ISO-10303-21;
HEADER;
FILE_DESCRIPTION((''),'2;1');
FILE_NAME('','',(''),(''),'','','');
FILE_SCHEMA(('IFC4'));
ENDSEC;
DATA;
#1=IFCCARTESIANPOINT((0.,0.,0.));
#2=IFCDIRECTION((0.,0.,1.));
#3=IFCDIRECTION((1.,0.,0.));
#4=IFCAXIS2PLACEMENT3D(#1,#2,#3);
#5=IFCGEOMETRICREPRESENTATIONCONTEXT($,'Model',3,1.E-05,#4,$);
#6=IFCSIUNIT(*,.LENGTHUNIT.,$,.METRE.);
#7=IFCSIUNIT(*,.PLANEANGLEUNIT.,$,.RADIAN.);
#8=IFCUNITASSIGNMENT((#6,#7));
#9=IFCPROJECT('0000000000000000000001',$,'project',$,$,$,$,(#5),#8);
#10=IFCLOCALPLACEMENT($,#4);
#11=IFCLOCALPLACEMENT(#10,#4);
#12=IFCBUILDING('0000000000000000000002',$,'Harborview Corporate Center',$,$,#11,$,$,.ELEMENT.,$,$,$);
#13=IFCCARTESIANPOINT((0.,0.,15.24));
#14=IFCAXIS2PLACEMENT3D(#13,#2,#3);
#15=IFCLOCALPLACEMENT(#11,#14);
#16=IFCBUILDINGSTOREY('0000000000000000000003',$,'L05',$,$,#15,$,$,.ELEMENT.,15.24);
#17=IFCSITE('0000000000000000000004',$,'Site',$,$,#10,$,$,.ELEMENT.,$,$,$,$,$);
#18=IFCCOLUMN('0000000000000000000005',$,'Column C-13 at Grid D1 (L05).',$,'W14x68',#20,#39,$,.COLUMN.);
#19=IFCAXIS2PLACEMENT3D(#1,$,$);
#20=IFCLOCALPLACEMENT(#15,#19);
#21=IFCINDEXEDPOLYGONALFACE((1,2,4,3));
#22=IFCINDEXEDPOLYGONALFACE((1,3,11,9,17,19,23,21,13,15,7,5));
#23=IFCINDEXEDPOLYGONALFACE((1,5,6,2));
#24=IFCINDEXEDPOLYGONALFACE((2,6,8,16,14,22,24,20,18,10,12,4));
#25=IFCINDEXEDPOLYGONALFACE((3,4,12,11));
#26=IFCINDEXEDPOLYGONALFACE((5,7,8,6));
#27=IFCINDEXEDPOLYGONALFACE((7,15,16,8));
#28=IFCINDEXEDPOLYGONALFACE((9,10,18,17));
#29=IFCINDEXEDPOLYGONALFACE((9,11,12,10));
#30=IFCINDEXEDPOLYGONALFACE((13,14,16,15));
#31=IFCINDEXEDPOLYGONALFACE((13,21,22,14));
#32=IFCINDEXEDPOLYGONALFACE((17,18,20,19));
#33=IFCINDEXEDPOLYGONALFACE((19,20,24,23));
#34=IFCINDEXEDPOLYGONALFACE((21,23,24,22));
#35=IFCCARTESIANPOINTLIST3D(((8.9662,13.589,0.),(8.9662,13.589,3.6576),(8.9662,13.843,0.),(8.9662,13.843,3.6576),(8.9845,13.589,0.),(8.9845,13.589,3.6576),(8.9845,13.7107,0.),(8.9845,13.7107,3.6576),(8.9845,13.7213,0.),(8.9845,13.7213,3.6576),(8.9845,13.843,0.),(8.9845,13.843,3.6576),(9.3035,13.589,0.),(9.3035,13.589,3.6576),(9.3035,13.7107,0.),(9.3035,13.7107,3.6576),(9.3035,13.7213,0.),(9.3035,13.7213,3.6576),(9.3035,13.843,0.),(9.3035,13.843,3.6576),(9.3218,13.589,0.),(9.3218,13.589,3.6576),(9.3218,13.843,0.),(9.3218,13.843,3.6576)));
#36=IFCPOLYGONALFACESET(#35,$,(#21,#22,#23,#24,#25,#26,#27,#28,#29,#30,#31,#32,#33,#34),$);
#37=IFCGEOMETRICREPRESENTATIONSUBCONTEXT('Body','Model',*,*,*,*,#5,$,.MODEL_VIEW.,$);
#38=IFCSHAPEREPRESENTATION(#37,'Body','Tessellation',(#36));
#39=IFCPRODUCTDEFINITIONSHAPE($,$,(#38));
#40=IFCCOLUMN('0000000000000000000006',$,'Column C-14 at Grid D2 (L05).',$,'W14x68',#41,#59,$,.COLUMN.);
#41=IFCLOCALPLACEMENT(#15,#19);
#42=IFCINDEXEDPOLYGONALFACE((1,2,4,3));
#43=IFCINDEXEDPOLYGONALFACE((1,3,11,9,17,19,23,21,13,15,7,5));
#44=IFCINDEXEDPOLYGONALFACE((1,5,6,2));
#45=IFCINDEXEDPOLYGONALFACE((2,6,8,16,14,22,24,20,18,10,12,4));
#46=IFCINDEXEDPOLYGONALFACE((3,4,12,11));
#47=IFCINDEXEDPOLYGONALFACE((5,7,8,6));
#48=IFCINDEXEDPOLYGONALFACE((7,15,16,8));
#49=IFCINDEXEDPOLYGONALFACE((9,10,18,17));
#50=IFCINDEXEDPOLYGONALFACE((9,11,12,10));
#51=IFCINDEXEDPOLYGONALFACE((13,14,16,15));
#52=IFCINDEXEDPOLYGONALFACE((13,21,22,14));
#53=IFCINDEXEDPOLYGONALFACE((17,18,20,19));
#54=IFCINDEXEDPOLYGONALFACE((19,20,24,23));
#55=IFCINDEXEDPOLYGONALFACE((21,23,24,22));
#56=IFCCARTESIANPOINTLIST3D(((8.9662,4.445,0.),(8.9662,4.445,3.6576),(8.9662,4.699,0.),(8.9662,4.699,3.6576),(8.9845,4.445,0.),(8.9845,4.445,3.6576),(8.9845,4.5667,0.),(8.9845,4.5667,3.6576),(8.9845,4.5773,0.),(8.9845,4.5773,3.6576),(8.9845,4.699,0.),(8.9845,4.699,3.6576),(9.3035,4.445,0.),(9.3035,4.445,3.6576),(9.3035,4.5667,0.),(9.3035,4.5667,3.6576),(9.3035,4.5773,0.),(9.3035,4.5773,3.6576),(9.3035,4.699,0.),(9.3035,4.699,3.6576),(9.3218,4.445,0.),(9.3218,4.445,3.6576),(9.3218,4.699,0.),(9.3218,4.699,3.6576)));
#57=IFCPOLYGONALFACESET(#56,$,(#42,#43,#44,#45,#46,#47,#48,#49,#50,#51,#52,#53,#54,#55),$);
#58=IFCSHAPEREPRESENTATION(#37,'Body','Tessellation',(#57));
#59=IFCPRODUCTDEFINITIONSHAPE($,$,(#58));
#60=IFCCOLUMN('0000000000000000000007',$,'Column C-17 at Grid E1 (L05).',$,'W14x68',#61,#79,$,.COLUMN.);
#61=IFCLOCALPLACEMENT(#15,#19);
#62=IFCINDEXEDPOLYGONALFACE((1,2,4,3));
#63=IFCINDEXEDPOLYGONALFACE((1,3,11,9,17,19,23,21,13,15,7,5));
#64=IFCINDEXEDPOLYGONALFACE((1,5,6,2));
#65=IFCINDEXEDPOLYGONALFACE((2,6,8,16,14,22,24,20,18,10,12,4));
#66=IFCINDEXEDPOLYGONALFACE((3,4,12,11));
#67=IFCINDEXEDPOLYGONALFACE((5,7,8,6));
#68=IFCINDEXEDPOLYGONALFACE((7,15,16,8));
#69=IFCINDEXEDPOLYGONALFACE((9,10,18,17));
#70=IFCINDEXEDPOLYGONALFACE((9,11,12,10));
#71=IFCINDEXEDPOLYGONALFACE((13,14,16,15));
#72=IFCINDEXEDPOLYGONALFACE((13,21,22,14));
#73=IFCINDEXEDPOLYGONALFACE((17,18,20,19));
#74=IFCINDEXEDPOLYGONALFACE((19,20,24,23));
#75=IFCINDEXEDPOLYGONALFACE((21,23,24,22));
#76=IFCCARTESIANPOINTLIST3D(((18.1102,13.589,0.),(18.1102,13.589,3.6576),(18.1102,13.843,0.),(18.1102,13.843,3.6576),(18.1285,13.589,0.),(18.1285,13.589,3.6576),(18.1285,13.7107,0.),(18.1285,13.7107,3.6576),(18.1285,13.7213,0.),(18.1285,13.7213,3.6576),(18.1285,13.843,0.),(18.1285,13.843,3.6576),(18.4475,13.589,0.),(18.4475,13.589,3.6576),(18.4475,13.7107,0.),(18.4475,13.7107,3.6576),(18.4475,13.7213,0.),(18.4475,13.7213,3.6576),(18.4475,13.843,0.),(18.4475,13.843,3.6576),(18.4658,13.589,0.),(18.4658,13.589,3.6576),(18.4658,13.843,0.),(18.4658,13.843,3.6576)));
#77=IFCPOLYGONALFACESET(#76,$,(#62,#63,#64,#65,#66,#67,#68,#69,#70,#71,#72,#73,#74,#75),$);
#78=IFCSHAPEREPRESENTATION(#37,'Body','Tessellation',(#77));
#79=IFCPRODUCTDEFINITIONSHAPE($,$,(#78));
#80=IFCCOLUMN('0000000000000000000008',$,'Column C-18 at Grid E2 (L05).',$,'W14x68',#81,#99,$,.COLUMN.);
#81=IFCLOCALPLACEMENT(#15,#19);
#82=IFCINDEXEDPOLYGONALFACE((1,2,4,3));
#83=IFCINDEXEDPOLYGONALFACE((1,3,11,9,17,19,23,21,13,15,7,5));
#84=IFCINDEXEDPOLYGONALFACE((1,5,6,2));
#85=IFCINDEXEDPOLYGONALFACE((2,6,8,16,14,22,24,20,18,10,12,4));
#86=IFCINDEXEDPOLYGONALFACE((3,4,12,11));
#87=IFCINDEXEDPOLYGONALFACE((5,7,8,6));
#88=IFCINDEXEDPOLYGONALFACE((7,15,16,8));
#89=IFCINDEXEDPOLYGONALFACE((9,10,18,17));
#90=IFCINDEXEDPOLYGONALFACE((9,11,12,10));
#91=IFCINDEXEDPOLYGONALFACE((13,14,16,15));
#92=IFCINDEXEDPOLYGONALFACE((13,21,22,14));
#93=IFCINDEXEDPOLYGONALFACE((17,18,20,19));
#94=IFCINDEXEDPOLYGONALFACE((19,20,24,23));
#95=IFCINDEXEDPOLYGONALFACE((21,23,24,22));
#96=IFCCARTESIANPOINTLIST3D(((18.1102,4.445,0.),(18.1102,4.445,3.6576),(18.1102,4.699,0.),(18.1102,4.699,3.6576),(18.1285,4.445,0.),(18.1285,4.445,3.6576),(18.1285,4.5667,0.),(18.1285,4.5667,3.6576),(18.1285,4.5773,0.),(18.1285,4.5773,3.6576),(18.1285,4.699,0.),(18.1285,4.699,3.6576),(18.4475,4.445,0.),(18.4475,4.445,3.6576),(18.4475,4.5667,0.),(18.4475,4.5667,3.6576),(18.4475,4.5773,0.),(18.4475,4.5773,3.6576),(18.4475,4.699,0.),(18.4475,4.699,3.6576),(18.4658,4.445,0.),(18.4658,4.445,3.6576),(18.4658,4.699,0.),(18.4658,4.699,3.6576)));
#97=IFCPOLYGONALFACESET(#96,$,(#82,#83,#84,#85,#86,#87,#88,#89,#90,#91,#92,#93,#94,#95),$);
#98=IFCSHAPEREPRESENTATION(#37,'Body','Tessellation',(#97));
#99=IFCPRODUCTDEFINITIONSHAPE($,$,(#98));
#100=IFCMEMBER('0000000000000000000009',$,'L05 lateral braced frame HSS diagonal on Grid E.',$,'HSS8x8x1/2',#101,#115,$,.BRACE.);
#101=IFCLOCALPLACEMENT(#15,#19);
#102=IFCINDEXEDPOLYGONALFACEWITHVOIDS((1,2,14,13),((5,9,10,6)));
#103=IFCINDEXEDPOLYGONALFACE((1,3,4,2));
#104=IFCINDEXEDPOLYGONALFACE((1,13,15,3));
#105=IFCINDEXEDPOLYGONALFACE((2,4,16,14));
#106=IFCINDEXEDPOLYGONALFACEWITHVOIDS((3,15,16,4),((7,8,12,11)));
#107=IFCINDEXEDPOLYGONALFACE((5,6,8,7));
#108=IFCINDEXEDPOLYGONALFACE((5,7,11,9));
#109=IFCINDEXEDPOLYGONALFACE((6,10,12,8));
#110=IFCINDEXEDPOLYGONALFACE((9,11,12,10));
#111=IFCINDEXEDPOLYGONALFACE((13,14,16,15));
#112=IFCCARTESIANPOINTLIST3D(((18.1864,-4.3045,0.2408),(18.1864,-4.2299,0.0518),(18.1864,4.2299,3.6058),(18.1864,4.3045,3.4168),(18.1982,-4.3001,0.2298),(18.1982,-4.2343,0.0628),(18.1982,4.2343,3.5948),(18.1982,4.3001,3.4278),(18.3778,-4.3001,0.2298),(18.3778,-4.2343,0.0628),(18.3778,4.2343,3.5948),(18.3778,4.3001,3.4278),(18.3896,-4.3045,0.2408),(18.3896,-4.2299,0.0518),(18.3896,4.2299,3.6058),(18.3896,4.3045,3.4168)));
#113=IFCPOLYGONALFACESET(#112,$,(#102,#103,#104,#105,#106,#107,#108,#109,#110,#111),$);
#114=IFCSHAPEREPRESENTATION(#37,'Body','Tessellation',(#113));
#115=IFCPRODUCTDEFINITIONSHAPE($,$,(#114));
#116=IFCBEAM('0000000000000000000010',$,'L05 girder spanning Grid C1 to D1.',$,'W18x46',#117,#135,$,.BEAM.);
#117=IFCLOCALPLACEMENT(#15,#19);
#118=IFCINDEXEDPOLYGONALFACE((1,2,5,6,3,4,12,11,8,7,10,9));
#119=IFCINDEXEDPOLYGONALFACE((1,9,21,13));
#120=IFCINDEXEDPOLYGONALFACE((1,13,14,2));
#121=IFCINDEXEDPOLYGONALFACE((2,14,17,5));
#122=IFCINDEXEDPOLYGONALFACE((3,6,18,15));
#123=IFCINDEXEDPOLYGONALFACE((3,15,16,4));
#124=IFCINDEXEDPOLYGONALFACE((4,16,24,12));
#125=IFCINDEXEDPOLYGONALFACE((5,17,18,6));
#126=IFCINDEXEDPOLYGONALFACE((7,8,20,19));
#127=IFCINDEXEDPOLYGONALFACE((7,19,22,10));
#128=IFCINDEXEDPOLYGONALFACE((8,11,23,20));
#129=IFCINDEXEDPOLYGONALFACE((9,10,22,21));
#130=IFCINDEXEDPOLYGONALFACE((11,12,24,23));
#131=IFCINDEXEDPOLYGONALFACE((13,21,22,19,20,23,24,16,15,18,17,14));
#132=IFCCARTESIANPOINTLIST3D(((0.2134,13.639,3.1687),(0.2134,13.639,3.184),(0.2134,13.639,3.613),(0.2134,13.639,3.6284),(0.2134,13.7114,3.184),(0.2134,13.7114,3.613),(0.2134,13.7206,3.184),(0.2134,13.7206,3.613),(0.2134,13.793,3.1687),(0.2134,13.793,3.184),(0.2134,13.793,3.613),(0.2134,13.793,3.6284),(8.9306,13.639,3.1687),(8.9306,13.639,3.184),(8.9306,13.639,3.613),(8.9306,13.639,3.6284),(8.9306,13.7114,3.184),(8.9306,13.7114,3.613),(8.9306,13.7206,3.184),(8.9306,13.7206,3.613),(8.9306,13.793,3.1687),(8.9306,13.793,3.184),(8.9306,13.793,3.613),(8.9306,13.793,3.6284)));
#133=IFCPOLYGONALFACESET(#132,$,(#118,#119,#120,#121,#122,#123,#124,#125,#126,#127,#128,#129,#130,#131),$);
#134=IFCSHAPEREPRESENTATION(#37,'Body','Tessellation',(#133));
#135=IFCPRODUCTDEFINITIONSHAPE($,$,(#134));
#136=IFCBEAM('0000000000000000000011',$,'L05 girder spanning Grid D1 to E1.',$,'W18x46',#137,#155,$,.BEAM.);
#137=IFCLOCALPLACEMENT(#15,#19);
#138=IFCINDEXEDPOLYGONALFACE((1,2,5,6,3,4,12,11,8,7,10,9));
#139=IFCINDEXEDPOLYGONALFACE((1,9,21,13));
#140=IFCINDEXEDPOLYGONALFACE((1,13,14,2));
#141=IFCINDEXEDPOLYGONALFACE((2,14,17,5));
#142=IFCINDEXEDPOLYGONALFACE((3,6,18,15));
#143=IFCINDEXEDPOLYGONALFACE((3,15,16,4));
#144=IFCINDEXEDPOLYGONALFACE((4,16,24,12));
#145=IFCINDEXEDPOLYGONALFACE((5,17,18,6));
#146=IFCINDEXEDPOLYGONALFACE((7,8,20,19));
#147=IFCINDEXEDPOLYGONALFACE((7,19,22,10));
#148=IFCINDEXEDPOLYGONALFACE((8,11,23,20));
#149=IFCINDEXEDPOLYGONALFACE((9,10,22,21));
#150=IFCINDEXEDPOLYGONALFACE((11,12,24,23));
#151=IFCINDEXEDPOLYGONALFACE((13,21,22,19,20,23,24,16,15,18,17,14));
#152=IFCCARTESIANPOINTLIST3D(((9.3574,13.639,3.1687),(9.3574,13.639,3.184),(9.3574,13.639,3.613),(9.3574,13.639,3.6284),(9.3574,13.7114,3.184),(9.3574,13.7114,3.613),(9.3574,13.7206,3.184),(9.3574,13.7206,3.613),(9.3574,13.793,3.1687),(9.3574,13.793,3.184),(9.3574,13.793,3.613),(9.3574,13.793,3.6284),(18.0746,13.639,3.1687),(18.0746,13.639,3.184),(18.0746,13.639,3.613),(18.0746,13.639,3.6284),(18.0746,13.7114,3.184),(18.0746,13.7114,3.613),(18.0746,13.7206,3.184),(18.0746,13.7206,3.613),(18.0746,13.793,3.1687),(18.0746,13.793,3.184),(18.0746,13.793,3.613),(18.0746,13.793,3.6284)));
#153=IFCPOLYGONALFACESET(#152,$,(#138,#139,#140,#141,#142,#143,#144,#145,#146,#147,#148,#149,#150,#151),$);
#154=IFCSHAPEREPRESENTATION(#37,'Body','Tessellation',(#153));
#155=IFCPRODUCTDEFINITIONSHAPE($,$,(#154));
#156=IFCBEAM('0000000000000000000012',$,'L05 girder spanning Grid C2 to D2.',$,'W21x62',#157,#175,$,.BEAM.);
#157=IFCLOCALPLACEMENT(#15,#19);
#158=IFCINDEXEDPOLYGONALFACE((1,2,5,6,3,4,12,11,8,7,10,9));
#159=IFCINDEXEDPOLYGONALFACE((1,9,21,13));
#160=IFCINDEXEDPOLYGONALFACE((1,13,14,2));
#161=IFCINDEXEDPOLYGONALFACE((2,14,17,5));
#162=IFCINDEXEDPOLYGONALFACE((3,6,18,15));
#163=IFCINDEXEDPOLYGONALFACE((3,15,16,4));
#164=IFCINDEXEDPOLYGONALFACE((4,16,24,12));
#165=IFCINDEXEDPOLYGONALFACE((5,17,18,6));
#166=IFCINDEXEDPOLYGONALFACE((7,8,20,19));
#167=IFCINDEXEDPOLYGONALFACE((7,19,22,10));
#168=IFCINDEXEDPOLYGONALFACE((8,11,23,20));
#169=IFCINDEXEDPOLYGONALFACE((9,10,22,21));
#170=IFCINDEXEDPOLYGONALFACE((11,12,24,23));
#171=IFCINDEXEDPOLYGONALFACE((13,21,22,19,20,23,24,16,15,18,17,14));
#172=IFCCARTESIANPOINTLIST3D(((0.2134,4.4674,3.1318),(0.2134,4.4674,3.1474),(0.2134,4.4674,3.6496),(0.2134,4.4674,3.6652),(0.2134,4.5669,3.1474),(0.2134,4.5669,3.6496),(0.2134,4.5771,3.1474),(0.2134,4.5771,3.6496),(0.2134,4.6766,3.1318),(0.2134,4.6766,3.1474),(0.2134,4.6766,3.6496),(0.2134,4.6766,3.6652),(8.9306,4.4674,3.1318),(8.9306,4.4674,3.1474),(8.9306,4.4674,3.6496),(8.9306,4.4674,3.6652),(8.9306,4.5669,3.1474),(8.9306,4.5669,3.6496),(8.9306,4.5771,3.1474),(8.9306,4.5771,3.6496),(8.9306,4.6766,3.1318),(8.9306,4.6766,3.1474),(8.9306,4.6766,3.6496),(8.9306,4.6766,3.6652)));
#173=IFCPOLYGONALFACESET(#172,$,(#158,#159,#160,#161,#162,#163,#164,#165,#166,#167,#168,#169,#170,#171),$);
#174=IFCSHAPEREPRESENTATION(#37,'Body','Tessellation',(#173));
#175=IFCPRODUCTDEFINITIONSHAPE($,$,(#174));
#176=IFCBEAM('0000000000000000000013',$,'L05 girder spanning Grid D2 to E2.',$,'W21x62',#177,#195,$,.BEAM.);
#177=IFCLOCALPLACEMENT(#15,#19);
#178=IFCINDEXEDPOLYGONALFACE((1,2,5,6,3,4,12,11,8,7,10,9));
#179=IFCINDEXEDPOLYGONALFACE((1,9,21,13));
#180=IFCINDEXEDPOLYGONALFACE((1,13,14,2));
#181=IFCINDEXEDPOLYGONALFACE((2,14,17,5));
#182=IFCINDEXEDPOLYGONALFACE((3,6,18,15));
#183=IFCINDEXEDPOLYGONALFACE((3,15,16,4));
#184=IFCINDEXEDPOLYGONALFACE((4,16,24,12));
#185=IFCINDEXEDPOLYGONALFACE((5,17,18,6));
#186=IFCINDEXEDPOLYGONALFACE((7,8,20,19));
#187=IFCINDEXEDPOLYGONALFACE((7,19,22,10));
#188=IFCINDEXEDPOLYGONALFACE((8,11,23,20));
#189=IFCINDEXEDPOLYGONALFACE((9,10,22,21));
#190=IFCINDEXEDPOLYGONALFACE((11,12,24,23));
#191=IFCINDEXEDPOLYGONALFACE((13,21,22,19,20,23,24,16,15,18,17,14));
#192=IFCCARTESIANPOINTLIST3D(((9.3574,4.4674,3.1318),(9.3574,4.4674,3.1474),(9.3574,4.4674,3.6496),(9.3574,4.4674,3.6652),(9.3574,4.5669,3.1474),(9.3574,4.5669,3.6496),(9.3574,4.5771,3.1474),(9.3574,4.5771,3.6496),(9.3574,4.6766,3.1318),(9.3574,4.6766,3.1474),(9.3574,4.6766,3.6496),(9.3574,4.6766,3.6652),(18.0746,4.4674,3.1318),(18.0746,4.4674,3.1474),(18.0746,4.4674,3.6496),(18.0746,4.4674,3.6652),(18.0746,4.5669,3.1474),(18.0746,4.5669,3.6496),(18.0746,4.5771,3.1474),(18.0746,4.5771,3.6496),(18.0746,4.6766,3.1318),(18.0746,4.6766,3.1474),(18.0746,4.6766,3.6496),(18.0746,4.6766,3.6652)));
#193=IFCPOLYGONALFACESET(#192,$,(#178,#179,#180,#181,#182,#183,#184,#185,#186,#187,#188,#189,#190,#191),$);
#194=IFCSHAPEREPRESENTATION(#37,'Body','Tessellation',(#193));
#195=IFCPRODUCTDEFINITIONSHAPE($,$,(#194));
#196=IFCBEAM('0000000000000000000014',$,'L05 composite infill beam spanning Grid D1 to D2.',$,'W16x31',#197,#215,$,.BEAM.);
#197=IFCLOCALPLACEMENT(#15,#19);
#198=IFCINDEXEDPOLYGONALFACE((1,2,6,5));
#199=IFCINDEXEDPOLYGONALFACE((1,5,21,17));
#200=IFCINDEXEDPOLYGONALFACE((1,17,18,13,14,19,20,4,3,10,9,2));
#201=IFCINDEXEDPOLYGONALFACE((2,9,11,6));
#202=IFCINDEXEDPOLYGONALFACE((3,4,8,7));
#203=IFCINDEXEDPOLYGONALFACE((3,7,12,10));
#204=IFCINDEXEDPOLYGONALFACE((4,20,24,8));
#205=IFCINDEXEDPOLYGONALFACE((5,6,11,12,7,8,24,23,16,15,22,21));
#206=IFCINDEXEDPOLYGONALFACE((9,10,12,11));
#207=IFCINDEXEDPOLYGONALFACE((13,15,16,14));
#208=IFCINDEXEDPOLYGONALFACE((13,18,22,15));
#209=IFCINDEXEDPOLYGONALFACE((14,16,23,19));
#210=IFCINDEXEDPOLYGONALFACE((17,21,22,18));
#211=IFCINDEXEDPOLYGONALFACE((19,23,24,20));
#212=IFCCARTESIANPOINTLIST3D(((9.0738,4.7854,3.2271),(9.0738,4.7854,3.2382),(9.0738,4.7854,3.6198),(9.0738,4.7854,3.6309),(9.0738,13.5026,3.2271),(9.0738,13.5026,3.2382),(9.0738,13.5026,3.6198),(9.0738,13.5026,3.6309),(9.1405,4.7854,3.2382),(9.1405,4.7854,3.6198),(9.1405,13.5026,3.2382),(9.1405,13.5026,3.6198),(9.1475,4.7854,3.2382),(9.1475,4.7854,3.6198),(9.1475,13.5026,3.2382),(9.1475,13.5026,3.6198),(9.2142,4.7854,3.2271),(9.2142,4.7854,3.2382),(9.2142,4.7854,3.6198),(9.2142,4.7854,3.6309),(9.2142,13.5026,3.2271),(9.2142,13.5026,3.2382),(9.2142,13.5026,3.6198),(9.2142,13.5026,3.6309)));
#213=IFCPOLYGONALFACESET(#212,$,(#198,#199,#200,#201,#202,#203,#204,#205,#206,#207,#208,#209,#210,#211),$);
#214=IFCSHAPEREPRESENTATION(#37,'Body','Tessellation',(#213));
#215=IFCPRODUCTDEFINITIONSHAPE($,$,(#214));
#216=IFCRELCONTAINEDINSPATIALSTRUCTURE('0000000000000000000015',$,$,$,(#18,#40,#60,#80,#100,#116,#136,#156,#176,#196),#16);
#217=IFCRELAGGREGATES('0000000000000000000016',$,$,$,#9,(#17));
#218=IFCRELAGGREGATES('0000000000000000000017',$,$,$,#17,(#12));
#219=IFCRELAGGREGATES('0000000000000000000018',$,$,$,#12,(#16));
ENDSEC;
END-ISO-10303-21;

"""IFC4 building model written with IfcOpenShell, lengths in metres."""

from ifc_helpers import new_model, si_unit, frame, origin_with_axes, place, context, subcontext, project, spatial, hollow_rectangle, i_section, extrude, element, save


model = new_model("IFC4")

# Units and contexts
model_context = context("Model", 3, precision=1e-05, world=origin_with_axes())
body_context = subcontext(model_context, "Body", "Model", "MODEL_VIEW")
ifc_project = project(units=[si_unit("LENGTHUNIT", "METRE"), si_unit("PLANEANGLEUNIT", "RADIAN")], contexts=[model_context])

# Site, building, storey
site_placement = place(None, origin_with_axes())
site = spatial("IfcSite", under=ifc_project, at=site_placement, Name="Site", CompositionType="ELEMENT")
building_placement = place(site_placement, origin_with_axes())
building = spatial("IfcBuilding", under=site, at=building_placement, Name="Harborview Corporate Center", CompositionType="ELEMENT")
storey_placement = place(building_placement, frame((0.0, 0.0, 15.24), z_axis=(0.0, 0.0, 1.0), x_axis=(1.0, 0.0, 0.0)))
storey = spatial("IfcBuildingStorey", under=building, at=storey_placement, Name="L05", CompositionType="ELEMENT", Elevation=15.24)

# Columns
for number, where, z_axis, x_axis, name in (
    (1, (9.144, 13.716, 0.0), (0.0, 0.0, 1.0), (0.0, 1.0, 0.0), "Column C-13 at Grid D1 (L05)."),
    (2, (9.144, 4.572, 0.0), (0.0, 0.0, 1.0), (0.0, 1.0, 0.0), "Column C-14 at Grid D2 (L05)."),
    (3, (18.288, 13.716, 0.0), (0.0, 0.0, 1.0), (0.0, 1.0, 0.0), "Column C-17 at Grid E1 (L05)."),
    (4, (18.288, 4.572, 0.0), (0.0, 0.0, 1.0), (0.0, 1.0, 0.0), "Column C-18 at Grid E2 (L05)."),
):
    element("IfcColumn", number, at=place(storey_placement, frame(where, z_axis=z_axis, x_axis=x_axis)), inside=storey, Name=name, ObjectType="W14x68", PredefinedType="COLUMN", context=body_context, shape_type="SweptSolid", body=[
        extrude(i_section(OverallWidth=0.254, OverallDepth=0.3556, WebThickness=0.0105, FlangeThickness=0.0183), origin_with_axes(), (0.0, 0.0, 1.0), 3.6576),
    ])

# Member
member_placement = place(storey_placement, frame((18.288, -4.2672, 0.1463), z_axis=(0.0, 0.930298, 0.366803), x_axis=(-1.0, 0.0, 0.0)))
element("IfcMember", 5, at=member_placement, inside=storey, Name="L05 lateral braced frame HSS diagonal on Grid E.", ObjectType="HSS8x8x1/2", PredefinedType="BRACE", context=body_context, shape_type="SweptSolid", body=[
    extrude(hollow_rectangle(XDim=0.2032, YDim=0.2032, WallThickness=0.0118), origin_with_axes(), (0.0, 0.0, 1.0), 9.1738),
])

# Beams
beam_1_placement = place(storey_placement, frame((0.2134, 13.716, 3.3985), z_axis=(1.0, 0.0, 0.0), x_axis=(0.0, 1.0, 0.0)))
element("IfcBeam", 6, at=beam_1_placement, inside=storey, Name="L05 girder spanning Grid C1 to D1.", ObjectType="W18x46", PredefinedType="BEAM", context=body_context, shape_type="SweptSolid", body=[
    extrude(i_section(OverallWidth=0.1539, OverallDepth=0.4597, WebThickness=0.0091, FlangeThickness=0.0154), origin_with_axes(), (0.0, 0.0, 1.0), 8.7173),
])
beam_2_placement = place(storey_placement, frame((9.3574, 13.716, 3.3985), z_axis=(1.0, 0.0, 0.0), x_axis=(0.0, 1.0, 0.0)))
element("IfcBeam", 7, at=beam_2_placement, inside=storey, Name="L05 girder spanning Grid D1 to E1.", ObjectType="W18x46", PredefinedType="BEAM", context=body_context, shape_type="SweptSolid", body=[
    extrude(i_section(OverallWidth=0.1539, OverallDepth=0.4597, WebThickness=0.0091, FlangeThickness=0.0154), origin_with_axes(), (0.0, 0.0, 1.0), 8.7173),
])
beam_3_placement = place(storey_placement, frame((0.2134, 4.572, 3.3985), z_axis=(1.0, 0.0, 0.0), x_axis=(0.0, 1.0, 0.0)))
element("IfcBeam", 8, at=beam_3_placement, inside=storey, Name="L05 girder spanning Grid C2 to D2.", ObjectType="W21x62", PredefinedType="BEAM", context=body_context, shape_type="SweptSolid", body=[
    extrude(i_section(OverallWidth=0.2093, OverallDepth=0.5334, WebThickness=0.0102, FlangeThickness=0.0156), origin_with_axes(), (0.0, 0.0, 1.0), 8.7173),
])
beam_4_placement = place(storey_placement, frame((9.3574, 4.572, 3.3985), z_axis=(1.0, 0.0, 0.0), x_axis=(0.0, 1.0, 0.0)))
element("IfcBeam", 9, at=beam_4_placement, inside=storey, Name="L05 girder spanning Grid D2 to E2.", ObjectType="W21x62", PredefinedType="BEAM", context=body_context, shape_type="SweptSolid", body=[
    extrude(i_section(OverallWidth=0.2093, OverallDepth=0.5334, WebThickness=0.0102, FlangeThickness=0.0156), origin_with_axes(), (0.0, 0.0, 1.0), 8.7173),
])
for number, where, z_axis, x_axis, name in (
    (10, (9.144, 4.7854, 3.429), (0.0, 1.0, 0.0), (-1.0, 0.0, 0.0), "L05 composite infill beam spanning Grid D1 to D2."),
):
    element("IfcBeam", number, at=place(storey_placement, frame(where, z_axis=z_axis, x_axis=x_axis)), inside=storey, Name=name, ObjectType="W16x31", PredefinedType="BEAM", context=body_context, shape_type="SweptSolid", body=[
        extrude(i_section(OverallWidth=0.1405, OverallDepth=0.4039, WebThickness=0.007, FlangeThickness=0.0112), origin_with_axes(), (0.0, 0.0, 1.0), 8.7173),
    ])

save(model, "model.ifc")
